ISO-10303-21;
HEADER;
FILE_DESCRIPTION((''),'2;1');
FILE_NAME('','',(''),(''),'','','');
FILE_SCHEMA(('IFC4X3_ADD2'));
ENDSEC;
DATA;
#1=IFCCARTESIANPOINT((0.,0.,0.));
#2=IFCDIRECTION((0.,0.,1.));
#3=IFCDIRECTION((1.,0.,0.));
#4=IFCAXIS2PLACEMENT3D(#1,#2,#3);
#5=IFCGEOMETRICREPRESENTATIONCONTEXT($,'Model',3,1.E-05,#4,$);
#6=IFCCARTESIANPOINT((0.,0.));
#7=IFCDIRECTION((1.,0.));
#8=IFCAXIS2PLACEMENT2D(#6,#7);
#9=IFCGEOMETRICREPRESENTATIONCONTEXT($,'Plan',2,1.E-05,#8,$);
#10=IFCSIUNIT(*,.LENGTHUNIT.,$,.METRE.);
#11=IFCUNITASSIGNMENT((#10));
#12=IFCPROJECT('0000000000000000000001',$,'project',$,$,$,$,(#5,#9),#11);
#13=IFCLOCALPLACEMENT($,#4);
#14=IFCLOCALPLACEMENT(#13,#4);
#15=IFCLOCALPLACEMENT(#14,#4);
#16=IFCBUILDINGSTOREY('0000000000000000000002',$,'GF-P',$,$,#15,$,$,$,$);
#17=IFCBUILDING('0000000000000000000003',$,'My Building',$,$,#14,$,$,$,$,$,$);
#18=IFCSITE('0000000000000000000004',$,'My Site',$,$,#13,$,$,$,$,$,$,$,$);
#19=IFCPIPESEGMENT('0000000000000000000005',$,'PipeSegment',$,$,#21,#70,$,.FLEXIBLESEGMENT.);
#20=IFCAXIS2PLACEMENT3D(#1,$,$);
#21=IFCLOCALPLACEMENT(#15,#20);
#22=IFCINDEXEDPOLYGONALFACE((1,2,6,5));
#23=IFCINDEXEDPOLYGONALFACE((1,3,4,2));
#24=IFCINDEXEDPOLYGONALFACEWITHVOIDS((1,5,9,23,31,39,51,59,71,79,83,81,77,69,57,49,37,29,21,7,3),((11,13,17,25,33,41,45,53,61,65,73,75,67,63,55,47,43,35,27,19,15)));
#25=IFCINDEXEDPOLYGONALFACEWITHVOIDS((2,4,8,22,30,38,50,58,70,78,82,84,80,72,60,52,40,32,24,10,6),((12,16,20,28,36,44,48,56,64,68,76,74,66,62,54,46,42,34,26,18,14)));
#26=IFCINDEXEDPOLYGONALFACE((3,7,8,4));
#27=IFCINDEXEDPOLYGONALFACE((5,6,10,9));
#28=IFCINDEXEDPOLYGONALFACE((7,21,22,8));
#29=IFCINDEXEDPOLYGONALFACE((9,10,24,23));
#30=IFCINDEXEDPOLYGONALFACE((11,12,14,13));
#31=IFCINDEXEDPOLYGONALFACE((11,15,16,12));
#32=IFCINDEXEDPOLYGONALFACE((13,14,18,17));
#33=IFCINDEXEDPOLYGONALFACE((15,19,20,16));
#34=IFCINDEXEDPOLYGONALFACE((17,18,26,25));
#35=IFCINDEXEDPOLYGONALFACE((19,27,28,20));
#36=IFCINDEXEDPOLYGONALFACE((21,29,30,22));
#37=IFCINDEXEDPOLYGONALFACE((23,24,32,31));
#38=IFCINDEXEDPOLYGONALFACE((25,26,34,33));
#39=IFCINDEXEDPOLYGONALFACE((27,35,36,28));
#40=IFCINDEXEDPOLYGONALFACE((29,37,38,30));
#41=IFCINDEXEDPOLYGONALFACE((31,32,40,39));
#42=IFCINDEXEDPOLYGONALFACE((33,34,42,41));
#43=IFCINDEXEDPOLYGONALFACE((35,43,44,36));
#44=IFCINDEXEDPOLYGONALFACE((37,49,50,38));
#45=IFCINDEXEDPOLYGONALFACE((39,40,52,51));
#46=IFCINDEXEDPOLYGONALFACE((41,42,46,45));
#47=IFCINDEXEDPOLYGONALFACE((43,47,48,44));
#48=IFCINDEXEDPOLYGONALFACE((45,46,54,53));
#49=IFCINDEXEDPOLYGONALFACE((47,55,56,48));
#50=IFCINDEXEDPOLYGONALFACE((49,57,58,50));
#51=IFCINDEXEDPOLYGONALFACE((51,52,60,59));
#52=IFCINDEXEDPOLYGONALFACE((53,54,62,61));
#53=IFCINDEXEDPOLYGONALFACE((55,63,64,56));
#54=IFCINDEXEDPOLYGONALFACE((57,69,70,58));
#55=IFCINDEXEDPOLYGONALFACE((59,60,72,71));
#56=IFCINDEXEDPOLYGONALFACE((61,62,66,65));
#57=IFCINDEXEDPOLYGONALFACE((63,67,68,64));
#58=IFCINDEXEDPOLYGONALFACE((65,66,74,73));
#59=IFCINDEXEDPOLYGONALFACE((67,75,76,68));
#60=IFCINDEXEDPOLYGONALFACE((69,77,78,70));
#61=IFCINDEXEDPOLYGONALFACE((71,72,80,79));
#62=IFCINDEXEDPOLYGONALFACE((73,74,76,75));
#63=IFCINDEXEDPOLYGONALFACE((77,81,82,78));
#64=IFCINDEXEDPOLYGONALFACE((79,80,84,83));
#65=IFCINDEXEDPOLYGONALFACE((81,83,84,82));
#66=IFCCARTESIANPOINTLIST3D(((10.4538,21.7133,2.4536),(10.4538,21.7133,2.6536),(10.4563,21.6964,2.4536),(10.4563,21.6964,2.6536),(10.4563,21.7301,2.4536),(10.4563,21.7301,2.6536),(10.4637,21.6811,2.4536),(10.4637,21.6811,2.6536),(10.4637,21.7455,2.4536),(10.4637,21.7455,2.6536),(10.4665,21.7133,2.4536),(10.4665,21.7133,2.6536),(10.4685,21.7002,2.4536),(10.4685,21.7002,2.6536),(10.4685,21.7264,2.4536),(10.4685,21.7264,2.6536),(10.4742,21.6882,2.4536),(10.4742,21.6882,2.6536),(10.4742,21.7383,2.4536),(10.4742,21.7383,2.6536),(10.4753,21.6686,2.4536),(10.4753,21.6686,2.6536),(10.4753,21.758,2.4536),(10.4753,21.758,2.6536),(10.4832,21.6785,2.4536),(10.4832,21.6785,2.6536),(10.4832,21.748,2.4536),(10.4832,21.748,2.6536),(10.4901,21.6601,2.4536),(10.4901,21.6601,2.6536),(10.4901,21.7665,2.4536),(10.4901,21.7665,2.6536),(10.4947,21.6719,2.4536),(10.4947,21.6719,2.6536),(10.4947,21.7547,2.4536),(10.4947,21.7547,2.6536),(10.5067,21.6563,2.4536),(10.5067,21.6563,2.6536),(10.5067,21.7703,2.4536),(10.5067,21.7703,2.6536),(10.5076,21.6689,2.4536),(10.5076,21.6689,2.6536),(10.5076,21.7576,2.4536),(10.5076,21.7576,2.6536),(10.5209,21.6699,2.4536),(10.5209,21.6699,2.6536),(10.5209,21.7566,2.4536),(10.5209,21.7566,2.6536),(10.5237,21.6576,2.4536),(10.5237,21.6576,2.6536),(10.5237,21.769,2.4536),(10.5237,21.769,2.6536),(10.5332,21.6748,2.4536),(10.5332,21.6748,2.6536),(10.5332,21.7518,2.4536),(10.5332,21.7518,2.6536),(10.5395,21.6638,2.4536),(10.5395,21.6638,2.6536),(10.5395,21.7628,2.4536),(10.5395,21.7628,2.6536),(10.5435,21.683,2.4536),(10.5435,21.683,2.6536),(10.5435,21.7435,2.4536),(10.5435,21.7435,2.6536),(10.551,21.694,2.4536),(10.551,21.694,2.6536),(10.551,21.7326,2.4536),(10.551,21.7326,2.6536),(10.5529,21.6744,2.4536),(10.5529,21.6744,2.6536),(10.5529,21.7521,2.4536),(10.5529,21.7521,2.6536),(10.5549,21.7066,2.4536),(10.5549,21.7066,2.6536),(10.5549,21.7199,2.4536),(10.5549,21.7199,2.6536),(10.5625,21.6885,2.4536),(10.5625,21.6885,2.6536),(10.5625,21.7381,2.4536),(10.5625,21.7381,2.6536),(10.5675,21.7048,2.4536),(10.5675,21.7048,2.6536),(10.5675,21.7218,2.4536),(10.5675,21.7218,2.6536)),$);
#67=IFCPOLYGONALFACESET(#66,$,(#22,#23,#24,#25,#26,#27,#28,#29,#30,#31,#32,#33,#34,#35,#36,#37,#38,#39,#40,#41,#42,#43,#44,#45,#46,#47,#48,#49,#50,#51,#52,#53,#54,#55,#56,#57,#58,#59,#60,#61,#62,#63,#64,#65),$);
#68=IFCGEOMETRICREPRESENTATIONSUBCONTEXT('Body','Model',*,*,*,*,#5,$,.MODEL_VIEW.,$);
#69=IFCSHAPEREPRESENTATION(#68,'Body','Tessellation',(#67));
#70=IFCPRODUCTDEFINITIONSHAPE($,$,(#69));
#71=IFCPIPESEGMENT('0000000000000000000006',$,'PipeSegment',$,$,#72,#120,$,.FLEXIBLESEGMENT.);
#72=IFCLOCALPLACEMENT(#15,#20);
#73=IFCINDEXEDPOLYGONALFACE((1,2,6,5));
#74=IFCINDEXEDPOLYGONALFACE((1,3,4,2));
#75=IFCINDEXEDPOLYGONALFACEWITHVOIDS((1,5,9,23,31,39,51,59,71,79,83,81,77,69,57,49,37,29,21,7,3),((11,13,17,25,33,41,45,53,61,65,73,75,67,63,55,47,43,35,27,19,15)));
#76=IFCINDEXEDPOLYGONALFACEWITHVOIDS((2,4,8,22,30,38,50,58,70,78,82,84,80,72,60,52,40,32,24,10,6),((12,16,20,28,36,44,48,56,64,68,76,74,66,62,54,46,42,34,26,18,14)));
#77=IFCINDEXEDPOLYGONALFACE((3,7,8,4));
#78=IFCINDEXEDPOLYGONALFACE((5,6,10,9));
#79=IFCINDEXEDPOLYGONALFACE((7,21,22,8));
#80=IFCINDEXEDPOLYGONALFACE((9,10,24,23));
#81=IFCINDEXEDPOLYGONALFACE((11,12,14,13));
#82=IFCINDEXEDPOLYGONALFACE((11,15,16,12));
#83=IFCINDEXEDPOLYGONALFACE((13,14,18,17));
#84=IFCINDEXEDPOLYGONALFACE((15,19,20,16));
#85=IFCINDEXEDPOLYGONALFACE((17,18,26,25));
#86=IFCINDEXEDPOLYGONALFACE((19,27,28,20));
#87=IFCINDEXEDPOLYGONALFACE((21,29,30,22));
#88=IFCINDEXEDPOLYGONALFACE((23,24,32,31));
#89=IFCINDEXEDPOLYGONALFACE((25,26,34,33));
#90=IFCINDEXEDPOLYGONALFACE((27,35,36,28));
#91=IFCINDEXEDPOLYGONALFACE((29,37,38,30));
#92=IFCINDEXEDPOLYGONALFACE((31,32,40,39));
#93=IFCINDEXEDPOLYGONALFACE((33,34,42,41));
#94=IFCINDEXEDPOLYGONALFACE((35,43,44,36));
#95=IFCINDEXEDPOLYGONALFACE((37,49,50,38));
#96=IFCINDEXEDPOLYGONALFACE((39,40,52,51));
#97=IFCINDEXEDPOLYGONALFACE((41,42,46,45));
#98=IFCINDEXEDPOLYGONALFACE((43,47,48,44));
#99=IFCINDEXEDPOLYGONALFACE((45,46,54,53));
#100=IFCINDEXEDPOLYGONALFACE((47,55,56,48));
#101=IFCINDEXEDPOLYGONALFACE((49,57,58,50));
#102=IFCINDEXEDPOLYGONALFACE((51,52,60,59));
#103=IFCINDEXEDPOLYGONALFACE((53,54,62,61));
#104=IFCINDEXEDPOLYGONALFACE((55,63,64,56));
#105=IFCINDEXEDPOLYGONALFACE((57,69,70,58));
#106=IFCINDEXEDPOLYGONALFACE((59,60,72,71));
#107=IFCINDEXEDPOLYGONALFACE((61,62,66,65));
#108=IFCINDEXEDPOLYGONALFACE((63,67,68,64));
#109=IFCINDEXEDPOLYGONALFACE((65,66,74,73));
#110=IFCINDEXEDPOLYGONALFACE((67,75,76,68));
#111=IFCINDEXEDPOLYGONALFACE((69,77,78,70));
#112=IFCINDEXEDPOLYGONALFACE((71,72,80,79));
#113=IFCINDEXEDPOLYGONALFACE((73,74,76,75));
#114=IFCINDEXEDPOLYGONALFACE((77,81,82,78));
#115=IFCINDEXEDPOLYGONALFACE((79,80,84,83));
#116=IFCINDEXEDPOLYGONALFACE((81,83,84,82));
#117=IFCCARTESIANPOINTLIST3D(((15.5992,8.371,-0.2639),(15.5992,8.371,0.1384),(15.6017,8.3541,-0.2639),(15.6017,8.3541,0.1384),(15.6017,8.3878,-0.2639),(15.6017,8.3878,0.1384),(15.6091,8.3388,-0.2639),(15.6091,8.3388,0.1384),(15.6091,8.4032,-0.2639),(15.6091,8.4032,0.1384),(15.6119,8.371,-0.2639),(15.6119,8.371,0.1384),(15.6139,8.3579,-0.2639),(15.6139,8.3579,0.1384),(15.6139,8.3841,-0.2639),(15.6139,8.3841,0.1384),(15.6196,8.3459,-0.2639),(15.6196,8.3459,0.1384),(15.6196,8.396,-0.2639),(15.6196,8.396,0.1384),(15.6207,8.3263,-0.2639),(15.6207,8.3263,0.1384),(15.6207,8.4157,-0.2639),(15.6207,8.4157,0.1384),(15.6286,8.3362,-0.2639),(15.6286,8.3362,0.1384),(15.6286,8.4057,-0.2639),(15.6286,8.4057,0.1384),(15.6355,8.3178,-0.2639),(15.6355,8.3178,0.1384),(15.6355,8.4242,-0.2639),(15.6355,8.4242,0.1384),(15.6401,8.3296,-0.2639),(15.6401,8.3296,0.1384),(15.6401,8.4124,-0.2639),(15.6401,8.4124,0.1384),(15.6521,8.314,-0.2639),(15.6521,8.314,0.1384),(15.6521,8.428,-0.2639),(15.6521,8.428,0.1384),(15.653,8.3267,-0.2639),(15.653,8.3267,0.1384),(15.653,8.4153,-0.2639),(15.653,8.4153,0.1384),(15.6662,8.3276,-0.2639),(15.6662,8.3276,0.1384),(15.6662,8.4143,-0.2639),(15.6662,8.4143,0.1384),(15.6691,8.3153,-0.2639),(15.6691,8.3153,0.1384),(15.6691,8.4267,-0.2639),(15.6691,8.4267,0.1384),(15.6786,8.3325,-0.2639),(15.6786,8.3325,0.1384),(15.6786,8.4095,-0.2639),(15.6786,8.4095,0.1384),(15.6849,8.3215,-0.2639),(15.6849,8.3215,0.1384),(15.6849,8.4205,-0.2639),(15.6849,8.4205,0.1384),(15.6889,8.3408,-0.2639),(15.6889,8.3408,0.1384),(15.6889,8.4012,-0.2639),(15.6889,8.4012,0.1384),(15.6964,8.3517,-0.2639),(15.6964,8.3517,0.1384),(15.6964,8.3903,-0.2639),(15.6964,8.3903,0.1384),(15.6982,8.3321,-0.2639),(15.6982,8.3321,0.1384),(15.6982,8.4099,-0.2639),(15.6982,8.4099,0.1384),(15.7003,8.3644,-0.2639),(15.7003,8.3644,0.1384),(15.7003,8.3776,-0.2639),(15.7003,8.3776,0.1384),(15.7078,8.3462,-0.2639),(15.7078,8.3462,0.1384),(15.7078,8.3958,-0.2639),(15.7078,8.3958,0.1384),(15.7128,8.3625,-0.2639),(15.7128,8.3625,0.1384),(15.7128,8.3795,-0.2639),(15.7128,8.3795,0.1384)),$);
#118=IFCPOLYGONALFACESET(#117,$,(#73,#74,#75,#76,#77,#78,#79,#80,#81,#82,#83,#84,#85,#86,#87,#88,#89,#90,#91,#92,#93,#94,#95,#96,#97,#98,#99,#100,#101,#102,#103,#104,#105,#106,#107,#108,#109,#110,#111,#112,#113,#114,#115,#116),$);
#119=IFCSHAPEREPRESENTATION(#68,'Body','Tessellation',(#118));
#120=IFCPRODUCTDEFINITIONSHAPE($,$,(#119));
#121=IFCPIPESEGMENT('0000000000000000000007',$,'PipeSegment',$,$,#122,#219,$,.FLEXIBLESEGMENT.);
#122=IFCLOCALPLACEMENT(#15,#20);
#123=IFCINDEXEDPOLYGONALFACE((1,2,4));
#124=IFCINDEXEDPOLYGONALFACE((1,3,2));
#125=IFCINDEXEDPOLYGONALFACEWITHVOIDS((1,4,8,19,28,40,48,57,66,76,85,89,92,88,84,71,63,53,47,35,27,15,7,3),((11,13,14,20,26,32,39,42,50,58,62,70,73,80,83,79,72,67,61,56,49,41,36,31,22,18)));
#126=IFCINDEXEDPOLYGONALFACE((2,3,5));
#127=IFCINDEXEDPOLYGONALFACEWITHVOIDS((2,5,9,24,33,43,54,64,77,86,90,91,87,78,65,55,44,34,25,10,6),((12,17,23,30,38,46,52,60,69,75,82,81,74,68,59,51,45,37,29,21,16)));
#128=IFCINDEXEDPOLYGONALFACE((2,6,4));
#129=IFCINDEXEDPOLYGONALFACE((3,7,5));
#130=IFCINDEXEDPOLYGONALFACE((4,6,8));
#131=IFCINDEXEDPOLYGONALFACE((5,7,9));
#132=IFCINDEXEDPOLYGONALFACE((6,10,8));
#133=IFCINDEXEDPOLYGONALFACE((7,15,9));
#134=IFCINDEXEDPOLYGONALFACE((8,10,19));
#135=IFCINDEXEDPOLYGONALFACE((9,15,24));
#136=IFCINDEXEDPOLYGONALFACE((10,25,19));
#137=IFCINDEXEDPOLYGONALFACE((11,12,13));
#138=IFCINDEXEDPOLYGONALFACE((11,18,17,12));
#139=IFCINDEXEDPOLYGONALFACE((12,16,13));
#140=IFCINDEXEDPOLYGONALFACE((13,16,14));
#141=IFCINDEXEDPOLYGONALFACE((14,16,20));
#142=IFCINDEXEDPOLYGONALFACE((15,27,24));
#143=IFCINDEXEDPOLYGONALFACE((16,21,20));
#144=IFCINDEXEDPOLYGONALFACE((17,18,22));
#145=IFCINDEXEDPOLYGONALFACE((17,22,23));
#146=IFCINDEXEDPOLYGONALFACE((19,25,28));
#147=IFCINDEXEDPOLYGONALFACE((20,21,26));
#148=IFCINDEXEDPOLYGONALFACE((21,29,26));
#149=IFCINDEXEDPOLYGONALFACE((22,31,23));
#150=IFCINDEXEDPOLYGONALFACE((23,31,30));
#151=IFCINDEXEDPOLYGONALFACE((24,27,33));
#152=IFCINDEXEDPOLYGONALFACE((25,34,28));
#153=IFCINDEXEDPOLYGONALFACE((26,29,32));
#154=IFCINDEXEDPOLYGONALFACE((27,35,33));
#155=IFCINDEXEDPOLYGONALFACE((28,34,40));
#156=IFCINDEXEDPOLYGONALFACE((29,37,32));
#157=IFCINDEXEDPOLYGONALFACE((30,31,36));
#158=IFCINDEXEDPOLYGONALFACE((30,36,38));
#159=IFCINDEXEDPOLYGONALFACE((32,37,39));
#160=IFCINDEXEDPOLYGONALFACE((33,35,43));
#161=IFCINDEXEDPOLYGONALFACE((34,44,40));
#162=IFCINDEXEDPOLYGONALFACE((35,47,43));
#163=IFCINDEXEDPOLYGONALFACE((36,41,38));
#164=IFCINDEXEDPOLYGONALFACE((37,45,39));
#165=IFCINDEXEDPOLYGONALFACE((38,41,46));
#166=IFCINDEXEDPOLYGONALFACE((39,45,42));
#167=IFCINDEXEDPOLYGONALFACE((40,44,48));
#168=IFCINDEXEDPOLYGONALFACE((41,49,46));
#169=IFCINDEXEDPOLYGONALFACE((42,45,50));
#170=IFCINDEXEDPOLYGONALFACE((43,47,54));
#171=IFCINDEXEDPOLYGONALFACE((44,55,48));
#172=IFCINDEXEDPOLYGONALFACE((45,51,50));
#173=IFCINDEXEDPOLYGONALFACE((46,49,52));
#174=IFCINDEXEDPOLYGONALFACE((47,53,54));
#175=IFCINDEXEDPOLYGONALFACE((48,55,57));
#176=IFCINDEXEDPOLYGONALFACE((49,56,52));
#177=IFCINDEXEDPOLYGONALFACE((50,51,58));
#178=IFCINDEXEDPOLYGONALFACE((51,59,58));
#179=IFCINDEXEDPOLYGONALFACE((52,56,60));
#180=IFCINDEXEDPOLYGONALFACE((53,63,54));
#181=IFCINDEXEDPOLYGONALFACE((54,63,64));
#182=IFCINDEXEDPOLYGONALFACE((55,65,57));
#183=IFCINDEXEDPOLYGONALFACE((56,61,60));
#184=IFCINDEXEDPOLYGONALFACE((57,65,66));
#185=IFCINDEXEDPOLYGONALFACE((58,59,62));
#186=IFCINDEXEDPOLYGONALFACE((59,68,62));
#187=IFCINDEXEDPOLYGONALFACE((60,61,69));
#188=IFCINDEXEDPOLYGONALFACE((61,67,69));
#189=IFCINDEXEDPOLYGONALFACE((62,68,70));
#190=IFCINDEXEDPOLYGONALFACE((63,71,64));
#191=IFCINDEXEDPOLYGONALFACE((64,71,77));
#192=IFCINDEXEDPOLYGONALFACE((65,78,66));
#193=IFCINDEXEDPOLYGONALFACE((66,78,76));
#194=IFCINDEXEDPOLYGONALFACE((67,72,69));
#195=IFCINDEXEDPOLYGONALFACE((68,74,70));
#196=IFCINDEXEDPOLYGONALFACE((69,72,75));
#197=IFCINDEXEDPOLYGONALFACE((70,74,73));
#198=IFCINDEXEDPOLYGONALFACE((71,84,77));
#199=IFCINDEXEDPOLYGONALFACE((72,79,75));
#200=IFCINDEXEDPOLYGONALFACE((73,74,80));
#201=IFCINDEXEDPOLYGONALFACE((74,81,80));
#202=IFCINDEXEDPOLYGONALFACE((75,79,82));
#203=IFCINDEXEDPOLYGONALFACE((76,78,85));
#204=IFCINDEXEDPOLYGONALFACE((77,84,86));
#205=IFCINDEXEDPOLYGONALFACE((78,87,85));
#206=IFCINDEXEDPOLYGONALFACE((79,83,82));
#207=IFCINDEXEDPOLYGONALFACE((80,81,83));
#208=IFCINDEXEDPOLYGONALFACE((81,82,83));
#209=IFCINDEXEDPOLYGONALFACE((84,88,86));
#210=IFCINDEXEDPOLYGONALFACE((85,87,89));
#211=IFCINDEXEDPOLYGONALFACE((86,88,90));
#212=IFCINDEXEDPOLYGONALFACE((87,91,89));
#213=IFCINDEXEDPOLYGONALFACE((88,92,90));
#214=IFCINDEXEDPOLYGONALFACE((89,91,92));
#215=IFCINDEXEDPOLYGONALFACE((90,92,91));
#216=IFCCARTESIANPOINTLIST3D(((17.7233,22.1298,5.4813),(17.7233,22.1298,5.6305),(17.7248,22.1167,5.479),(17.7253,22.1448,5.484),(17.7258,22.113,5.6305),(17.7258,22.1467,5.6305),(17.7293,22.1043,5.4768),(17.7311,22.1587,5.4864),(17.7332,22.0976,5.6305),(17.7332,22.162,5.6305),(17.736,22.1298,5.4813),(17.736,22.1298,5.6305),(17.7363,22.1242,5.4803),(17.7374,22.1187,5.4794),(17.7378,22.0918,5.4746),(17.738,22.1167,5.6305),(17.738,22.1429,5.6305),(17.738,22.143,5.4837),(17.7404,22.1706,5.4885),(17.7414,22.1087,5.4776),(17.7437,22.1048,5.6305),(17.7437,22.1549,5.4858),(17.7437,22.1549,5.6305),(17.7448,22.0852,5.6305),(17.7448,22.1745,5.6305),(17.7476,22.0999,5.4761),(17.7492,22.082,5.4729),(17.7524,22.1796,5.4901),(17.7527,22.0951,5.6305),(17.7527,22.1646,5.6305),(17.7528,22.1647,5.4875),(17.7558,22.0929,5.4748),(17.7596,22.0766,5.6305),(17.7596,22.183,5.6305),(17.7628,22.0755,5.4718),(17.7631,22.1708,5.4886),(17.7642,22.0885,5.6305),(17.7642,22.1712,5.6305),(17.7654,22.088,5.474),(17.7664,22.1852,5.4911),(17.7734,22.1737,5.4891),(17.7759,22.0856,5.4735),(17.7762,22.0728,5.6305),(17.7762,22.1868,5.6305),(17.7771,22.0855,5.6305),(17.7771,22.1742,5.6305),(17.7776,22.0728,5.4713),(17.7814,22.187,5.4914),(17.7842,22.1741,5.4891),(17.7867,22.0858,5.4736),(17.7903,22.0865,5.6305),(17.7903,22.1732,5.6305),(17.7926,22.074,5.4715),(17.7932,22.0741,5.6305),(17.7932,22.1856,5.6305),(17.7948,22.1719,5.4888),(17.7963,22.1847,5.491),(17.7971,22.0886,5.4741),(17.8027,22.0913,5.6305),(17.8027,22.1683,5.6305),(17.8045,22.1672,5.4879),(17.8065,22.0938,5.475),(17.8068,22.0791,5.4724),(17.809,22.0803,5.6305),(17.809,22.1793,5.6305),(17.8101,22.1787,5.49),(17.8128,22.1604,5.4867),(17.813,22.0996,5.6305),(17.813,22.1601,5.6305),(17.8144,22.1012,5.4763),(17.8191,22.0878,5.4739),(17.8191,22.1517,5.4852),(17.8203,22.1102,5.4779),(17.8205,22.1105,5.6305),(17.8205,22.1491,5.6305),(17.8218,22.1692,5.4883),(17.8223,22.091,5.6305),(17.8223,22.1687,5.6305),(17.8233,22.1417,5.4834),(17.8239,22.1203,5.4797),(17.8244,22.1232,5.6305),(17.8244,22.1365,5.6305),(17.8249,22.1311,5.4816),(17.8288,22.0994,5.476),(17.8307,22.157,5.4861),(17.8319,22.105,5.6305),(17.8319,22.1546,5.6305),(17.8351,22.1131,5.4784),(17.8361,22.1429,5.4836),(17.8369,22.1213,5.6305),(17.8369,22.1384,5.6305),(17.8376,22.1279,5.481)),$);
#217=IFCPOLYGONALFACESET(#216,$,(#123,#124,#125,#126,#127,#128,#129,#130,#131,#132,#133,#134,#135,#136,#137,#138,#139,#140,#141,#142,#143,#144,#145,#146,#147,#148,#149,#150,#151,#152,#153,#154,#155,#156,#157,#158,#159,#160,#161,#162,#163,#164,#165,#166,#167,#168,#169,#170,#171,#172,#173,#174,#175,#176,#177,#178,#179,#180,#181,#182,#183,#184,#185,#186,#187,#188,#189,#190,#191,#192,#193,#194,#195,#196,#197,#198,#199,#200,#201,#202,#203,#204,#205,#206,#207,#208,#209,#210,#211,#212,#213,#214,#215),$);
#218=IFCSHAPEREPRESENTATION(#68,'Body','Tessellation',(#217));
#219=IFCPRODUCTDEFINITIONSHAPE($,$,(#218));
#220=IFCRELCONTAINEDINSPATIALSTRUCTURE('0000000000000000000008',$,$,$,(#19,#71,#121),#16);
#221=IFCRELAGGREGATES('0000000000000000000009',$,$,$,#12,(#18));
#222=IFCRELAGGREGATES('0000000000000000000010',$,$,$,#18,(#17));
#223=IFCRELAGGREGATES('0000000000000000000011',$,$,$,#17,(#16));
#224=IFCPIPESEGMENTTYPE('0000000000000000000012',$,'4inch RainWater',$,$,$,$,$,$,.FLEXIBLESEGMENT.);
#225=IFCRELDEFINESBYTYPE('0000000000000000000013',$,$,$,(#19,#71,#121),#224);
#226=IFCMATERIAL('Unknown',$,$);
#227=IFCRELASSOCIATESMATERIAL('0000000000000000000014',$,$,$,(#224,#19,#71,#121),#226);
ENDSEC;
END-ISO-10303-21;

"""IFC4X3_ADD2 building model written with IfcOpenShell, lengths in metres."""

from ifc_helpers import new_model, si_unit, frame, origin_with_axes, origin_2d_with_axis, place, context, subcontext, project, spatial, hollow_circle, extrude, clip, halfspace, material, material_profile, profile_set, profile_usage, type_object, element, save


model = new_model("IFC4X3_ADD2")

# Units and contexts
model_context = context("Model", 3, precision=1e-05, world=origin_with_axes())
plan_context = context("Plan", 2, precision=1e-05, world=origin_2d_with_axis())
body_context = subcontext(model_context, "Body", "Model", "MODEL_VIEW")
ifc_project = project(units=[si_unit("LENGTHUNIT", "METRE")], contexts=[model_context, plan_context])

# Site, building, storey
site_placement = place(None, origin_with_axes())
site = spatial("IfcSite", under=ifc_project, at=site_placement, Name="My Site")
building_placement = place(site_placement, origin_with_axes())
building = spatial("IfcBuilding", under=site, at=building_placement, Name="My Building")
storey_placement = place(building_placement, origin_with_axes())
storey = spatial("IfcBuildingStorey", under=building, at=storey_placement, Name="GF-P")

# Shared definitions
ifc_material_1 = material(Name="Unknown")

# Pipe segments
ifc_material_profile_1 = material_profile(ifc_material_1, hollow_circle(Radius=0.0571, WallThickness=0.0127))
ifc_profile_set_1 = profile_set([ifc_material_profile_1], Name="rainwater")
pipe_segment_type_1 = type_object("IfcPipeSegmentType", Name="4inch RainWater", PredefinedType="FLEXIBLESEGMENT", material=ifc_profile_set_1)
ifc_profile_usage_1 = profile_usage(ifc_profile_set_1)
pipe_segment_1_placement = place(storey_placement, frame((10.511, 21.7133, 2.4536), z_axis=(0.0, 0.0, 1.0), x_axis=(-1.0, 0.0, 0.0)))
element("IfcPipeSegment", 1, at=pipe_segment_1_placement, inside=storey, type_object=pipe_segment_type_1, material=ifc_profile_usage_1, Name="PipeSegment", PredefinedType="FLEXIBLESEGMENT", context=body_context, shape_type="SweptSolid", body=[
    extrude(hollow_circle(Radius=0.0571, WallThickness=0.0127), origin_with_axes(), (0.0, 0.0, 1.0), 0.2),
])
ifc_profile_usage_2 = profile_usage(ifc_profile_set_1)
pipe_segment_2_placement = place(storey_placement, frame((15.6563, 8.371, -0.2639), z_axis=(0.0, 0.0, 1.0), x_axis=(-1.0, 0.0, 0.0)))
element("IfcPipeSegment", 2, at=pipe_segment_2_placement, inside=storey, type_object=pipe_segment_type_1, material=ifc_profile_usage_2, Name="PipeSegment", PredefinedType="FLEXIBLESEGMENT", context=body_context, shape_type="SweptSolid", body=[
    extrude(hollow_circle(Radius=0.0571, WallThickness=0.0127), origin_with_axes(), (0.0, 0.0, 1.0), 0.4022),
])
ifc_profile_usage_3 = profile_usage(ifc_profile_set_1)
pipe_segment_3_placement = place(storey_placement, frame((17.7804, 22.1298, 5.367), z_axis=(0.0, 0.0, 1.0), x_axis=(-1.0, 0.0, 0.0)))
element("IfcPipeSegment", 3, at=pipe_segment_3_placement, inside=storey, type_object=pipe_segment_type_1, material=ifc_profile_usage_3, Name="PipeSegment", PredefinedType="FLEXIBLESEGMENT", context=body_context, shape_type="Clipping", body=[
    clip(extrude(hollow_circle(Radius=0.0571, WallThickness=0.0127), origin_with_axes(), (0.0, 0.0, 1.0), 0.2634), halfspace(frame((0.0, 0.8743, -0.0399), z_axis=(0.0, -0.173648, -0.984808), x_axis=(-1.0, 0.0, 0.0)), False)),
])

save(model, "model.ifc")
